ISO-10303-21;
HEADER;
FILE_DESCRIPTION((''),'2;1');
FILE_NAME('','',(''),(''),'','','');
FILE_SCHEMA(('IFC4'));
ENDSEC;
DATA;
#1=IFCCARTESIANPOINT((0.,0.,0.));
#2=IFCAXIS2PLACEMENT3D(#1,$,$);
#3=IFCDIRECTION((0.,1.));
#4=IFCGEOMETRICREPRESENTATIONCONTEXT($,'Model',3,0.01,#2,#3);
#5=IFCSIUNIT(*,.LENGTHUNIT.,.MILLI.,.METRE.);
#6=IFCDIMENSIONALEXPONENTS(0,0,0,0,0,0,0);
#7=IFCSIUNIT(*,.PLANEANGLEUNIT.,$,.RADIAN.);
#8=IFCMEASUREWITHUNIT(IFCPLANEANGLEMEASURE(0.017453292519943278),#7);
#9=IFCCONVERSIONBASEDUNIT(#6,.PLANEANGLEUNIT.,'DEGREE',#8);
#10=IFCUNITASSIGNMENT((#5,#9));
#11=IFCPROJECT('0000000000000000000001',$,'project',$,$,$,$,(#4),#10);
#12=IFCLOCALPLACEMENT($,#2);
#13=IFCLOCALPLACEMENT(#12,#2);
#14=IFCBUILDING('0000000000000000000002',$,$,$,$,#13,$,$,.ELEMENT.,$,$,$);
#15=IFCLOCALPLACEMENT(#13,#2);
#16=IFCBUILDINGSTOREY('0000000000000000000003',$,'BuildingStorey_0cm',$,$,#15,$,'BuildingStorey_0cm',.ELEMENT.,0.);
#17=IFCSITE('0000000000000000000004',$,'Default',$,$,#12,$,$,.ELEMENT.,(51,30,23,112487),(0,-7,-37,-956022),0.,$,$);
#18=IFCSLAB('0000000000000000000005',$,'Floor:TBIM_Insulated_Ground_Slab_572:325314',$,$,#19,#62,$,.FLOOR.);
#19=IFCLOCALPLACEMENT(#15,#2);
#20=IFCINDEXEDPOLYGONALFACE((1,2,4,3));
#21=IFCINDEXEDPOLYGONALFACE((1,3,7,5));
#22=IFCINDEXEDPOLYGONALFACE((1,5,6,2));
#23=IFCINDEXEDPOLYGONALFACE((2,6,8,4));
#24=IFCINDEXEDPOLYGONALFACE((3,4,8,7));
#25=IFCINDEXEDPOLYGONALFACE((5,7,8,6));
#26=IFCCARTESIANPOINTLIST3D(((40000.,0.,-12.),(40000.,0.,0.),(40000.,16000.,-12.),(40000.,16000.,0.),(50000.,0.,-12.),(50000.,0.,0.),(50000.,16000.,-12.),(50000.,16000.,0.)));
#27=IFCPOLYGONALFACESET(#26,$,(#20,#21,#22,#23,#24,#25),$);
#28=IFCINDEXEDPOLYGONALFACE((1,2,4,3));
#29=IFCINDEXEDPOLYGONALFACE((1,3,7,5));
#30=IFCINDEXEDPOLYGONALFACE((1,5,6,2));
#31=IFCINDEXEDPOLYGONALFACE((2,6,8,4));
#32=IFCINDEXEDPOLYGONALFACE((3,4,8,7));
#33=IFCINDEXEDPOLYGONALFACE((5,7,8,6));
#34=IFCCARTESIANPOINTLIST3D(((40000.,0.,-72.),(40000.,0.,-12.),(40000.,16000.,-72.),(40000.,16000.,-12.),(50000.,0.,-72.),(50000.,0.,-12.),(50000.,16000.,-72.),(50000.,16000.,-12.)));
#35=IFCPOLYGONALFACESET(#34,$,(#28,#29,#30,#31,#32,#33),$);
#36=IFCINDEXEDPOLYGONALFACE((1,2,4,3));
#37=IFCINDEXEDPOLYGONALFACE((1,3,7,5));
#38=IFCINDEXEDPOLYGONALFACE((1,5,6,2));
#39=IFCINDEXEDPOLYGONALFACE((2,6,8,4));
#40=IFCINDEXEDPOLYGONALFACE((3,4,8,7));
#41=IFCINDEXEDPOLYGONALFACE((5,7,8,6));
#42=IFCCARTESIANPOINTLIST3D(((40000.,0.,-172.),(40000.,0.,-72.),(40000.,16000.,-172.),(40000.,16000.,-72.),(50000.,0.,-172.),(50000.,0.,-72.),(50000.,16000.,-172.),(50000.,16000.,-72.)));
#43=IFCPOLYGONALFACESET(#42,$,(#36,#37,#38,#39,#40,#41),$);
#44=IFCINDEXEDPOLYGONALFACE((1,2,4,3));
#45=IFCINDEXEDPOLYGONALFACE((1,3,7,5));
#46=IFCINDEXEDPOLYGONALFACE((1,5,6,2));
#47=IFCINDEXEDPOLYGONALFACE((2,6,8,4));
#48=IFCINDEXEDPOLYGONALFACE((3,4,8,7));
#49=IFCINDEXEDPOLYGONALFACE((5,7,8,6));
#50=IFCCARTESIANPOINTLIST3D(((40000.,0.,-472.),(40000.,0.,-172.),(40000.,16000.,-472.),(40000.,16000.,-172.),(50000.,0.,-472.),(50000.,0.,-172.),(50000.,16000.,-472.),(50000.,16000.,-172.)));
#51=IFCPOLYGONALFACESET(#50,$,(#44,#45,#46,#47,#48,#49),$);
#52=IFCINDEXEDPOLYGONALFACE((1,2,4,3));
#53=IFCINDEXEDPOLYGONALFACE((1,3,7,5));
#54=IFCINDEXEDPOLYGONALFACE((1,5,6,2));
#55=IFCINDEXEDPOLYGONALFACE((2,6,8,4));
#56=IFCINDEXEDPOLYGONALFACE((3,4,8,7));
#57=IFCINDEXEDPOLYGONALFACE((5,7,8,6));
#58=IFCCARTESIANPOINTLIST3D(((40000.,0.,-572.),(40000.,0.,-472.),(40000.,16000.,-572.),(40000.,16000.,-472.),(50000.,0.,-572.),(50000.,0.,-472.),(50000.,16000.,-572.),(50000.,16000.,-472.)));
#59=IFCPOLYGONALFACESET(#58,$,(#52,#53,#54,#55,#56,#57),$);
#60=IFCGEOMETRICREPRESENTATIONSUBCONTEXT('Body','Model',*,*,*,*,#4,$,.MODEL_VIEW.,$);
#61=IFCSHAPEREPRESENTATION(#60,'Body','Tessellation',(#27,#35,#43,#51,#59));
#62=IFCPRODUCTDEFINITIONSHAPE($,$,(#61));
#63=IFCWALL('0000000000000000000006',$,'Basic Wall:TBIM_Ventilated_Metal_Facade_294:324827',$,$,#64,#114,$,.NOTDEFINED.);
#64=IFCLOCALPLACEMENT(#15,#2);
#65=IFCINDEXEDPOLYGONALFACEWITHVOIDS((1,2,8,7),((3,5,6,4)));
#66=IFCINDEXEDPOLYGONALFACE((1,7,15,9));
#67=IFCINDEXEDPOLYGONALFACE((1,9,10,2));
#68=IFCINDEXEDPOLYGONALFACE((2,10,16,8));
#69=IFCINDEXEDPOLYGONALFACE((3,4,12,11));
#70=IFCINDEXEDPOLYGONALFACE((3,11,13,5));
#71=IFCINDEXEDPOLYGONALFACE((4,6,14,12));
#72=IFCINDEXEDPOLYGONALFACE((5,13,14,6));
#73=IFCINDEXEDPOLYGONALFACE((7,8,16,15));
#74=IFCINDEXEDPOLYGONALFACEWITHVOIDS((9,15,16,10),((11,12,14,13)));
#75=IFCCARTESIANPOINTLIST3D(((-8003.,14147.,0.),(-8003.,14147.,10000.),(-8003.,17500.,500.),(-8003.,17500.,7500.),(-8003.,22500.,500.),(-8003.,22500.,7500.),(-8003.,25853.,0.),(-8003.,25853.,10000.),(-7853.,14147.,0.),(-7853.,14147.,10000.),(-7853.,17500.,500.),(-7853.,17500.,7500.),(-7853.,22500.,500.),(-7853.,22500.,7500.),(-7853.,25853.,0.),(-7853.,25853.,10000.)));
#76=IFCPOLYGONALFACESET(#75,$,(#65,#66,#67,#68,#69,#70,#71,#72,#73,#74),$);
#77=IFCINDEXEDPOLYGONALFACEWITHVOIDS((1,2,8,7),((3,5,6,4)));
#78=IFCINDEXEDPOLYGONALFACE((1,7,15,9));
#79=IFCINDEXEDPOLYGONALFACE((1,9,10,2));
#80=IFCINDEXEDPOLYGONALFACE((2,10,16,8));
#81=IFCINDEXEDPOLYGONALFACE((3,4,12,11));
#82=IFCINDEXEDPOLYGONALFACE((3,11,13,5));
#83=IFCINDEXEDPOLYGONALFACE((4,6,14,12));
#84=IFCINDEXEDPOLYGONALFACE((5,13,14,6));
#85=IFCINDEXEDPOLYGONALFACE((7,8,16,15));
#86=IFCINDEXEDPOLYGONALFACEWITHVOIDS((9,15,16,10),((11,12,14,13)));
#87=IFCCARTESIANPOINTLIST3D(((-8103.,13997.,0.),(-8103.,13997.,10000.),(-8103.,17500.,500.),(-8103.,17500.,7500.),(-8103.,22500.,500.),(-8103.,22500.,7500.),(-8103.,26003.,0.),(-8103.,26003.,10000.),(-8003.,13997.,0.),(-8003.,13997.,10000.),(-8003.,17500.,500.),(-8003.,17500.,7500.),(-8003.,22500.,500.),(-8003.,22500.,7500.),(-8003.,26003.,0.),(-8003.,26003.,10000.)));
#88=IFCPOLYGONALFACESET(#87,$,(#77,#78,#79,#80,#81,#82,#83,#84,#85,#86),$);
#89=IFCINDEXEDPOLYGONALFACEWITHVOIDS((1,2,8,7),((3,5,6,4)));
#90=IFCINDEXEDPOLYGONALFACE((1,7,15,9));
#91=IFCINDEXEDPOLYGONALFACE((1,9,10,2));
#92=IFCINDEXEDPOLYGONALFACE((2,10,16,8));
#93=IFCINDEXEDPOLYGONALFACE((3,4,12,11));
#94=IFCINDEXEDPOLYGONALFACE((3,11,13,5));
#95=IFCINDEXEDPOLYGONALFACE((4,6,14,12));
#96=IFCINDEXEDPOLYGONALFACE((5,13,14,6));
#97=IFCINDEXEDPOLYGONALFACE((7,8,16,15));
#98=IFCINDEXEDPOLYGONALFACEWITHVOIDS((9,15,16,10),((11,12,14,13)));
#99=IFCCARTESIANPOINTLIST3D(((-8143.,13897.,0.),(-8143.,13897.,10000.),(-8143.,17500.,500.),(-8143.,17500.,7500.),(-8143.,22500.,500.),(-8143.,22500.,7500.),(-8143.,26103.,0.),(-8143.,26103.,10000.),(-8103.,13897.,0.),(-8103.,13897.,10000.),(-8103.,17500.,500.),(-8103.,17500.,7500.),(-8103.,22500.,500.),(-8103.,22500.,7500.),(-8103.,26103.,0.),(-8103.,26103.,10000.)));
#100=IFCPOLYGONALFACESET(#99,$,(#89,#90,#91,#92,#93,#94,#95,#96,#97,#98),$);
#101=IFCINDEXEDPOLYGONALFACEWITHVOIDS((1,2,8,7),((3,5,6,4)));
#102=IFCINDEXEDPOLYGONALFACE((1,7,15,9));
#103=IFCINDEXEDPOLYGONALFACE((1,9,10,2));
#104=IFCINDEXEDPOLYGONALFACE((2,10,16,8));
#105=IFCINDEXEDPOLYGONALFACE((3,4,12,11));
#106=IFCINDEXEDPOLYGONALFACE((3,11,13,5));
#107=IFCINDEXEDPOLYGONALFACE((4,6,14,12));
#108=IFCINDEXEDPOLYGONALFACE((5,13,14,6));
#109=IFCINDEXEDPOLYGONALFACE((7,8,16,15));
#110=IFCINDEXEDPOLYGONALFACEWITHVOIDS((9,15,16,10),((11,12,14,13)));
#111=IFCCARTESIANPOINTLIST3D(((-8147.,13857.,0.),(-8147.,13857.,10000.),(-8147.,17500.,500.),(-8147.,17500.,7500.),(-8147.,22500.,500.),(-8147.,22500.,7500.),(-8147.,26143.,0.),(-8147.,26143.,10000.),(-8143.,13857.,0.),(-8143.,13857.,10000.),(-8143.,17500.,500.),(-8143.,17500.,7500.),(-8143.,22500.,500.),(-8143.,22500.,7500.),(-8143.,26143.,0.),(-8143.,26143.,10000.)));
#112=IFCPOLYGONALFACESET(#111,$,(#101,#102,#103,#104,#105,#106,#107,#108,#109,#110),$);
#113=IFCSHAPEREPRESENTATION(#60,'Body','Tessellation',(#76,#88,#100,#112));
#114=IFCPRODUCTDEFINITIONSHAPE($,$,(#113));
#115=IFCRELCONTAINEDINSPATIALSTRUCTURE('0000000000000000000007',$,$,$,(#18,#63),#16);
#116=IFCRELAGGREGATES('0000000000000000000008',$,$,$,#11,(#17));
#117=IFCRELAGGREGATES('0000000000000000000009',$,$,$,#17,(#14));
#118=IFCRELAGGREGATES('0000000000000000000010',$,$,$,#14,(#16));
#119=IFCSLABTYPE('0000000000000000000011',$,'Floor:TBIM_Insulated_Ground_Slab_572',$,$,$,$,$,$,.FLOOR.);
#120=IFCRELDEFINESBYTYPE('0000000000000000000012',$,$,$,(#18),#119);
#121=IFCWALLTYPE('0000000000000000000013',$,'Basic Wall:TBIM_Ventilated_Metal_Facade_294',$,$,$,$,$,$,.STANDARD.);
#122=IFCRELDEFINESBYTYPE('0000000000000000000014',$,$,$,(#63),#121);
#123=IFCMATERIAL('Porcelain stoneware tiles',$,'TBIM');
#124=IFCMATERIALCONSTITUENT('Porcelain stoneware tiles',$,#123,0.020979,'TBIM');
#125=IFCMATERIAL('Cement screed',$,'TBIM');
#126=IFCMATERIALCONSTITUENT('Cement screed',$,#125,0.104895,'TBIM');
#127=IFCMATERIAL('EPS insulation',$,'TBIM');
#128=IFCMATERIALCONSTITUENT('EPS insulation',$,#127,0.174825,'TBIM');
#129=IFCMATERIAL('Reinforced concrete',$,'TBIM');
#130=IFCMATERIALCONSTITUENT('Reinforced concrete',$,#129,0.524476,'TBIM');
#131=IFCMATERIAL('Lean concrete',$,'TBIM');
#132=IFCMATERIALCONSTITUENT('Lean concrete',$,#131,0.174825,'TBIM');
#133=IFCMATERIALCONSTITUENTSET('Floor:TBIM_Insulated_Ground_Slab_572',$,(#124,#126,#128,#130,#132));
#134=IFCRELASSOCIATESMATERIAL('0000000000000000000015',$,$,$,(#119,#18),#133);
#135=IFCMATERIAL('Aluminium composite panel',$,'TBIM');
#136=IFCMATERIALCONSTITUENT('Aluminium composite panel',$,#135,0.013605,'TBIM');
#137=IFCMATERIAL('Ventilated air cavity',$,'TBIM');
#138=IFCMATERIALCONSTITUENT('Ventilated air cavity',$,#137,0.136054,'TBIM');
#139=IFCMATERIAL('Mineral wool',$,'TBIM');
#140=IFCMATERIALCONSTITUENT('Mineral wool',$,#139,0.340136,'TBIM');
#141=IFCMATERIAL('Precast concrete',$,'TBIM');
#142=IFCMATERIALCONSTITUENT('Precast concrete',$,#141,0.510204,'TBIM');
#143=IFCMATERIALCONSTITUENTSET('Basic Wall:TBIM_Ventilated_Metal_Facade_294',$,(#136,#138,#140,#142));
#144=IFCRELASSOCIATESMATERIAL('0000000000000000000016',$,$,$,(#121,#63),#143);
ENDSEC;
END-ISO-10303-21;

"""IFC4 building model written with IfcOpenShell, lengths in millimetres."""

from ifc_helpers import new_model, entity, si_unit, converted_unit, direction, frame, origin, place, context, subcontext, project, spatial, indexed_curve, outline, extrude, material, constituent, constituent_set, type_object, element, save


model = new_model("IFC4")

# Units and contexts
model_context = context("Model", 3, precision=0.01, world=origin(), true_north=direction((0.0, 1.0)))
body_context = subcontext(model_context, "Body", "Model", "MODEL_VIEW")
ifc_project = project(units=[si_unit("LENGTHUNIT", "METRE", prefix="MILLI"), converted_unit("PLANEANGLEUNIT", "DEGREE", entity("IfcPlaneAngleMeasure", 0.017453292519943278), si_unit("PLANEANGLEUNIT", "RADIAN"), dimensions=[0, 0, 0, 0, 0, 0, 0])], contexts=[model_context])

# Site, building, storey
site_placement = place(None, origin())
site = spatial("IfcSite", under=ifc_project, at=site_placement, Name="Default", CompositionType="ELEMENT", RefLatitude=(51, 30, 23, 112487), RefLongitude=(0, -7, -37, -956022), RefElevation=0.0)
building_placement = place(site_placement, origin())
building = spatial("IfcBuilding", under=site, at=building_placement, CompositionType="ELEMENT")
storey_placement = place(building_placement, origin())
storey = spatial("IfcBuildingStorey", under=building, at=storey_placement, Name="BuildingStorey_0cm", LongName="BuildingStorey_0cm", CompositionType="ELEMENT", Elevation=0.0)

# Slab
ifc_material_1 = material(Name="Porcelain stoneware tiles", Category="TBIM")
ifc_constituent_1 = constituent(ifc_material_1, Name="Porcelain stoneware tiles", Category="TBIM", fraction=0.020979)
ifc_material_2 = material(Name="Cement screed", Category="TBIM")
ifc_constituent_2 = constituent(ifc_material_2, Name="Cement screed", Category="TBIM", fraction=0.104895)
ifc_material_3 = material(Name="EPS insulation", Category="TBIM")
ifc_constituent_3 = constituent(ifc_material_3, Name="EPS insulation", Category="TBIM", fraction=0.174825)
ifc_material_4 = material(Name="Reinforced concrete", Category="TBIM")
ifc_constituent_4 = constituent(ifc_material_4, Name="Reinforced concrete", Category="TBIM", fraction=0.524476)
ifc_material_5 = material(Name="Lean concrete", Category="TBIM")
ifc_constituent_5 = constituent(ifc_material_5, Name="Lean concrete", Category="TBIM", fraction=0.174825)
ifc_constituent_set_1 = constituent_set(constituents=[ifc_constituent_1, ifc_constituent_2, ifc_constituent_3, ifc_constituent_4, ifc_constituent_5], Name="Floor:TBIM_Insulated_Ground_Slab_572")
slab_type = type_object("IfcSlabType", Name="Floor:TBIM_Insulated_Ground_Slab_572", PredefinedType="FLOOR", material=ifc_constituent_set_1)
slab_1_placement = place(storey_placement, origin())
element("IfcSlab", 1, at=slab_1_placement, inside=storey, type_object=slab_type, material=ifc_constituent_set_1, Name="Floor:TBIM_Insulated_Ground_Slab_572:325314", PredefinedType="FLOOR", context=body_context, shape_type="SweptSolid", body=[
    extrude(outline(indexed_curve([(-5000.0, -8000.0), (5000.0, -8000.0), (5000.0, 8000.0), (-5000.0, 8000.0), (-5000.0, -8000.0)], self_intersect=False)), frame((45000.0, 8000.0, -12.0), z_axis=(0.0, 0.0, 1.0), x_axis=(-1.0, 0.0, 0.0)), (0.0, 0.0, 1.0), 12.0),
    extrude(outline(indexed_curve([(-5000.0, -8000.0), (5000.0, -8000.0), (5000.0, 8000.0), (-5000.0, 8000.0), (-5000.0, -8000.0)], self_intersect=False)), frame((45000.0, 8000.0, -72.0), z_axis=(0.0, 0.0, 1.0), x_axis=(-1.0, 0.0, 0.0)), (0.0, 0.0, 1.0), 60.0),
    extrude(outline(indexed_curve([(-5000.0, -8000.0), (5000.0, -8000.0), (5000.0, 8000.0), (-5000.0, 8000.0), (-5000.0, -8000.0)], self_intersect=False)), frame((45000.0, 8000.0, -172.0), z_axis=(0.0, 0.0, 1.0), x_axis=(-1.0, 0.0, 0.0)), (0.0, 0.0, 1.0), 100.0),
    extrude(outline(indexed_curve([(-5000.0, -8000.0), (5000.0, -8000.0), (5000.0, 8000.0), (-5000.0, 8000.0), (-5000.0, -8000.0)], self_intersect=False)), frame((45000.0, 8000.0, -472.0), z_axis=(0.0, 0.0, 1.0), x_axis=(-1.0, 0.0, 0.0)), (0.0, 0.0, 1.0), 300.0),
    extrude(outline(indexed_curve([(-5000.0, -8000.0), (5000.0, -8000.0), (5000.0, 8000.0), (-5000.0, 8000.0), (-5000.0, -8000.0)], self_intersect=False)), frame((45000.0, 8000.0, -572.0), z_axis=(0.0, 0.0, 1.0), x_axis=(-1.0, 0.0, 0.0)), (0.0, 0.0, 1.0), 100.0),
])

# Wall, opening
ifc_material_6 = material(Name="Aluminium composite panel", Category="TBIM")
ifc_constituent_6 = constituent(ifc_material_6, Name="Aluminium composite panel", Category="TBIM", fraction=0.013605)
ifc_material_7 = material(Name="Ventilated air cavity", Category="TBIM")
ifc_constituent_7 = constituent(ifc_material_7, Name="Ventilated air cavity", Category="TBIM", fraction=0.136054)
ifc_material_8 = material(Name="Mineral wool", Category="TBIM")
ifc_constituent_8 = constituent(ifc_material_8, Name="Mineral wool", Category="TBIM", fraction=0.340136)
ifc_material_9 = material(Name="Precast concrete", Category="TBIM")
ifc_constituent_9 = constituent(ifc_material_9, Name="Precast concrete", Category="TBIM", fraction=0.510204)
ifc_constituent_set_2 = constituent_set(constituents=[ifc_constituent_6, ifc_constituent_7, ifc_constituent_8, ifc_constituent_9], Name="Basic Wall:TBIM_Ventilated_Metal_Facade_294")
wall_type_1 = type_object("IfcWallType", Name="Basic Wall:TBIM_Ventilated_Metal_Facade_294", PredefinedType="STANDARD", material=ifc_constituent_set_2)
wall_1_placement = place(storey_placement, frame((-8000.0, 14147.0, 0.0), z_axis=(0.0, 0.0, 1.0), x_axis=(0.0, 1.0, 0.0)))
wall_1 = element("IfcWall", 2, at=wall_1_placement, inside=storey, type_object=wall_type_1, material=ifc_constituent_set_2, Name="Basic Wall:TBIM_Ventilated_Metal_Facade_294:324827", PredefinedType="NOTDEFINED", context=body_context, shape_type="SweptSolid", body=[
    extrude(outline(indexed_curve([(-5000.0, -5853.0), (5000.0, -5853.0), (5000.0, 5853.0), (-5000.0, 5853.0), (-5000.0, -5853.0)], self_intersect=False), holes=[indexed_curve([(2500.0, 2500.0), (2500.0, -2500.0), (-4500.0, -2500.0), (-4500.0, 2500.0), (2500.0, 2500.0)], self_intersect=False)]), frame((5853.0, 3.0, 5000.0), z_axis=(0.0, -1.0, 0.0), x_axis=(0.0, 0.0, 1.0)), (0.0, 0.0, 1.0), 150.0),
    extrude(outline(indexed_curve([(-5000.0, -6003.0), (5000.0, -6003.0), (5000.0, 6003.0), (-5000.0, 6003.0), (-5000.0, -6003.0)], self_intersect=False), holes=[indexed_curve([(2500.0, 2500.0), (2500.0, -2500.0), (-4500.0, -2500.0), (-4500.0, 2500.0), (2500.0, 2500.0)], self_intersect=False)]), frame((5853.0, 103.0, 5000.0), z_axis=(0.0, -1.0, 0.0), x_axis=(0.0, 0.0, 1.0)), (0.0, 0.0, 1.0), 100.0),
    extrude(outline(indexed_curve([(-5000.0, -6103.0), (5000.0, -6103.0), (5000.0, 6103.0), (-5000.0, 6103.0), (-5000.0, -6103.0)], self_intersect=False), holes=[indexed_curve([(2500.0, 2500.0), (2500.0, -2500.0), (-4500.0, -2500.0), (-4500.0, 2500.0), (2500.0, 2500.0)], self_intersect=False)]), frame((5853.0, 143.0, 5000.0), z_axis=(0.0, -1.0, 0.0), x_axis=(0.0, 0.0, 1.0)), (0.0, 0.0, 1.0), 40.0),
    extrude(outline(indexed_curve([(-6143.0, -5000.0), (6143.0, -5000.0), (6143.0, 5000.0), (-6143.0, 5000.0), (-6143.0, -5000.0)], self_intersect=False), holes=[indexed_curve([(-2500.0, 2500.0), (2500.0, 2500.0), (2500.0, -4500.0), (-2500.0, -4500.0), (-2500.0, 2500.0)], self_intersect=False)]), frame((5853.0, 147.0, 5000.0), z_axis=(0.0, -1.0, 0.0), x_axis=(1.0, 0.0, 0.0)), (0.0, 0.0, 1.0), 4.0),
])
opening_1_placement = place(wall_1_placement, frame((3353.0, -147.0, 500.0)))
element("IfcOpeningElement", 3, at=opening_1_placement, cuts=wall_1, PredefinedType="OPENING", context=body_context, shape_type="SweptSolid", body=[
    extrude(outline(indexed_curve([(7000.0, 0.0), (7000.0, 5000.0), (0.0, 5000.0), (0.0, 0.0), (7000.0, 0.0)], self_intersect=False)), frame((0.0, 0.0, 0.0), z_axis=(0.0, 1.0, 0.0), x_axis=(0.0, 0.0, 1.0)), (0.0, 0.0, 1.0), 294.0),
])

save(model, "model.ifc")
